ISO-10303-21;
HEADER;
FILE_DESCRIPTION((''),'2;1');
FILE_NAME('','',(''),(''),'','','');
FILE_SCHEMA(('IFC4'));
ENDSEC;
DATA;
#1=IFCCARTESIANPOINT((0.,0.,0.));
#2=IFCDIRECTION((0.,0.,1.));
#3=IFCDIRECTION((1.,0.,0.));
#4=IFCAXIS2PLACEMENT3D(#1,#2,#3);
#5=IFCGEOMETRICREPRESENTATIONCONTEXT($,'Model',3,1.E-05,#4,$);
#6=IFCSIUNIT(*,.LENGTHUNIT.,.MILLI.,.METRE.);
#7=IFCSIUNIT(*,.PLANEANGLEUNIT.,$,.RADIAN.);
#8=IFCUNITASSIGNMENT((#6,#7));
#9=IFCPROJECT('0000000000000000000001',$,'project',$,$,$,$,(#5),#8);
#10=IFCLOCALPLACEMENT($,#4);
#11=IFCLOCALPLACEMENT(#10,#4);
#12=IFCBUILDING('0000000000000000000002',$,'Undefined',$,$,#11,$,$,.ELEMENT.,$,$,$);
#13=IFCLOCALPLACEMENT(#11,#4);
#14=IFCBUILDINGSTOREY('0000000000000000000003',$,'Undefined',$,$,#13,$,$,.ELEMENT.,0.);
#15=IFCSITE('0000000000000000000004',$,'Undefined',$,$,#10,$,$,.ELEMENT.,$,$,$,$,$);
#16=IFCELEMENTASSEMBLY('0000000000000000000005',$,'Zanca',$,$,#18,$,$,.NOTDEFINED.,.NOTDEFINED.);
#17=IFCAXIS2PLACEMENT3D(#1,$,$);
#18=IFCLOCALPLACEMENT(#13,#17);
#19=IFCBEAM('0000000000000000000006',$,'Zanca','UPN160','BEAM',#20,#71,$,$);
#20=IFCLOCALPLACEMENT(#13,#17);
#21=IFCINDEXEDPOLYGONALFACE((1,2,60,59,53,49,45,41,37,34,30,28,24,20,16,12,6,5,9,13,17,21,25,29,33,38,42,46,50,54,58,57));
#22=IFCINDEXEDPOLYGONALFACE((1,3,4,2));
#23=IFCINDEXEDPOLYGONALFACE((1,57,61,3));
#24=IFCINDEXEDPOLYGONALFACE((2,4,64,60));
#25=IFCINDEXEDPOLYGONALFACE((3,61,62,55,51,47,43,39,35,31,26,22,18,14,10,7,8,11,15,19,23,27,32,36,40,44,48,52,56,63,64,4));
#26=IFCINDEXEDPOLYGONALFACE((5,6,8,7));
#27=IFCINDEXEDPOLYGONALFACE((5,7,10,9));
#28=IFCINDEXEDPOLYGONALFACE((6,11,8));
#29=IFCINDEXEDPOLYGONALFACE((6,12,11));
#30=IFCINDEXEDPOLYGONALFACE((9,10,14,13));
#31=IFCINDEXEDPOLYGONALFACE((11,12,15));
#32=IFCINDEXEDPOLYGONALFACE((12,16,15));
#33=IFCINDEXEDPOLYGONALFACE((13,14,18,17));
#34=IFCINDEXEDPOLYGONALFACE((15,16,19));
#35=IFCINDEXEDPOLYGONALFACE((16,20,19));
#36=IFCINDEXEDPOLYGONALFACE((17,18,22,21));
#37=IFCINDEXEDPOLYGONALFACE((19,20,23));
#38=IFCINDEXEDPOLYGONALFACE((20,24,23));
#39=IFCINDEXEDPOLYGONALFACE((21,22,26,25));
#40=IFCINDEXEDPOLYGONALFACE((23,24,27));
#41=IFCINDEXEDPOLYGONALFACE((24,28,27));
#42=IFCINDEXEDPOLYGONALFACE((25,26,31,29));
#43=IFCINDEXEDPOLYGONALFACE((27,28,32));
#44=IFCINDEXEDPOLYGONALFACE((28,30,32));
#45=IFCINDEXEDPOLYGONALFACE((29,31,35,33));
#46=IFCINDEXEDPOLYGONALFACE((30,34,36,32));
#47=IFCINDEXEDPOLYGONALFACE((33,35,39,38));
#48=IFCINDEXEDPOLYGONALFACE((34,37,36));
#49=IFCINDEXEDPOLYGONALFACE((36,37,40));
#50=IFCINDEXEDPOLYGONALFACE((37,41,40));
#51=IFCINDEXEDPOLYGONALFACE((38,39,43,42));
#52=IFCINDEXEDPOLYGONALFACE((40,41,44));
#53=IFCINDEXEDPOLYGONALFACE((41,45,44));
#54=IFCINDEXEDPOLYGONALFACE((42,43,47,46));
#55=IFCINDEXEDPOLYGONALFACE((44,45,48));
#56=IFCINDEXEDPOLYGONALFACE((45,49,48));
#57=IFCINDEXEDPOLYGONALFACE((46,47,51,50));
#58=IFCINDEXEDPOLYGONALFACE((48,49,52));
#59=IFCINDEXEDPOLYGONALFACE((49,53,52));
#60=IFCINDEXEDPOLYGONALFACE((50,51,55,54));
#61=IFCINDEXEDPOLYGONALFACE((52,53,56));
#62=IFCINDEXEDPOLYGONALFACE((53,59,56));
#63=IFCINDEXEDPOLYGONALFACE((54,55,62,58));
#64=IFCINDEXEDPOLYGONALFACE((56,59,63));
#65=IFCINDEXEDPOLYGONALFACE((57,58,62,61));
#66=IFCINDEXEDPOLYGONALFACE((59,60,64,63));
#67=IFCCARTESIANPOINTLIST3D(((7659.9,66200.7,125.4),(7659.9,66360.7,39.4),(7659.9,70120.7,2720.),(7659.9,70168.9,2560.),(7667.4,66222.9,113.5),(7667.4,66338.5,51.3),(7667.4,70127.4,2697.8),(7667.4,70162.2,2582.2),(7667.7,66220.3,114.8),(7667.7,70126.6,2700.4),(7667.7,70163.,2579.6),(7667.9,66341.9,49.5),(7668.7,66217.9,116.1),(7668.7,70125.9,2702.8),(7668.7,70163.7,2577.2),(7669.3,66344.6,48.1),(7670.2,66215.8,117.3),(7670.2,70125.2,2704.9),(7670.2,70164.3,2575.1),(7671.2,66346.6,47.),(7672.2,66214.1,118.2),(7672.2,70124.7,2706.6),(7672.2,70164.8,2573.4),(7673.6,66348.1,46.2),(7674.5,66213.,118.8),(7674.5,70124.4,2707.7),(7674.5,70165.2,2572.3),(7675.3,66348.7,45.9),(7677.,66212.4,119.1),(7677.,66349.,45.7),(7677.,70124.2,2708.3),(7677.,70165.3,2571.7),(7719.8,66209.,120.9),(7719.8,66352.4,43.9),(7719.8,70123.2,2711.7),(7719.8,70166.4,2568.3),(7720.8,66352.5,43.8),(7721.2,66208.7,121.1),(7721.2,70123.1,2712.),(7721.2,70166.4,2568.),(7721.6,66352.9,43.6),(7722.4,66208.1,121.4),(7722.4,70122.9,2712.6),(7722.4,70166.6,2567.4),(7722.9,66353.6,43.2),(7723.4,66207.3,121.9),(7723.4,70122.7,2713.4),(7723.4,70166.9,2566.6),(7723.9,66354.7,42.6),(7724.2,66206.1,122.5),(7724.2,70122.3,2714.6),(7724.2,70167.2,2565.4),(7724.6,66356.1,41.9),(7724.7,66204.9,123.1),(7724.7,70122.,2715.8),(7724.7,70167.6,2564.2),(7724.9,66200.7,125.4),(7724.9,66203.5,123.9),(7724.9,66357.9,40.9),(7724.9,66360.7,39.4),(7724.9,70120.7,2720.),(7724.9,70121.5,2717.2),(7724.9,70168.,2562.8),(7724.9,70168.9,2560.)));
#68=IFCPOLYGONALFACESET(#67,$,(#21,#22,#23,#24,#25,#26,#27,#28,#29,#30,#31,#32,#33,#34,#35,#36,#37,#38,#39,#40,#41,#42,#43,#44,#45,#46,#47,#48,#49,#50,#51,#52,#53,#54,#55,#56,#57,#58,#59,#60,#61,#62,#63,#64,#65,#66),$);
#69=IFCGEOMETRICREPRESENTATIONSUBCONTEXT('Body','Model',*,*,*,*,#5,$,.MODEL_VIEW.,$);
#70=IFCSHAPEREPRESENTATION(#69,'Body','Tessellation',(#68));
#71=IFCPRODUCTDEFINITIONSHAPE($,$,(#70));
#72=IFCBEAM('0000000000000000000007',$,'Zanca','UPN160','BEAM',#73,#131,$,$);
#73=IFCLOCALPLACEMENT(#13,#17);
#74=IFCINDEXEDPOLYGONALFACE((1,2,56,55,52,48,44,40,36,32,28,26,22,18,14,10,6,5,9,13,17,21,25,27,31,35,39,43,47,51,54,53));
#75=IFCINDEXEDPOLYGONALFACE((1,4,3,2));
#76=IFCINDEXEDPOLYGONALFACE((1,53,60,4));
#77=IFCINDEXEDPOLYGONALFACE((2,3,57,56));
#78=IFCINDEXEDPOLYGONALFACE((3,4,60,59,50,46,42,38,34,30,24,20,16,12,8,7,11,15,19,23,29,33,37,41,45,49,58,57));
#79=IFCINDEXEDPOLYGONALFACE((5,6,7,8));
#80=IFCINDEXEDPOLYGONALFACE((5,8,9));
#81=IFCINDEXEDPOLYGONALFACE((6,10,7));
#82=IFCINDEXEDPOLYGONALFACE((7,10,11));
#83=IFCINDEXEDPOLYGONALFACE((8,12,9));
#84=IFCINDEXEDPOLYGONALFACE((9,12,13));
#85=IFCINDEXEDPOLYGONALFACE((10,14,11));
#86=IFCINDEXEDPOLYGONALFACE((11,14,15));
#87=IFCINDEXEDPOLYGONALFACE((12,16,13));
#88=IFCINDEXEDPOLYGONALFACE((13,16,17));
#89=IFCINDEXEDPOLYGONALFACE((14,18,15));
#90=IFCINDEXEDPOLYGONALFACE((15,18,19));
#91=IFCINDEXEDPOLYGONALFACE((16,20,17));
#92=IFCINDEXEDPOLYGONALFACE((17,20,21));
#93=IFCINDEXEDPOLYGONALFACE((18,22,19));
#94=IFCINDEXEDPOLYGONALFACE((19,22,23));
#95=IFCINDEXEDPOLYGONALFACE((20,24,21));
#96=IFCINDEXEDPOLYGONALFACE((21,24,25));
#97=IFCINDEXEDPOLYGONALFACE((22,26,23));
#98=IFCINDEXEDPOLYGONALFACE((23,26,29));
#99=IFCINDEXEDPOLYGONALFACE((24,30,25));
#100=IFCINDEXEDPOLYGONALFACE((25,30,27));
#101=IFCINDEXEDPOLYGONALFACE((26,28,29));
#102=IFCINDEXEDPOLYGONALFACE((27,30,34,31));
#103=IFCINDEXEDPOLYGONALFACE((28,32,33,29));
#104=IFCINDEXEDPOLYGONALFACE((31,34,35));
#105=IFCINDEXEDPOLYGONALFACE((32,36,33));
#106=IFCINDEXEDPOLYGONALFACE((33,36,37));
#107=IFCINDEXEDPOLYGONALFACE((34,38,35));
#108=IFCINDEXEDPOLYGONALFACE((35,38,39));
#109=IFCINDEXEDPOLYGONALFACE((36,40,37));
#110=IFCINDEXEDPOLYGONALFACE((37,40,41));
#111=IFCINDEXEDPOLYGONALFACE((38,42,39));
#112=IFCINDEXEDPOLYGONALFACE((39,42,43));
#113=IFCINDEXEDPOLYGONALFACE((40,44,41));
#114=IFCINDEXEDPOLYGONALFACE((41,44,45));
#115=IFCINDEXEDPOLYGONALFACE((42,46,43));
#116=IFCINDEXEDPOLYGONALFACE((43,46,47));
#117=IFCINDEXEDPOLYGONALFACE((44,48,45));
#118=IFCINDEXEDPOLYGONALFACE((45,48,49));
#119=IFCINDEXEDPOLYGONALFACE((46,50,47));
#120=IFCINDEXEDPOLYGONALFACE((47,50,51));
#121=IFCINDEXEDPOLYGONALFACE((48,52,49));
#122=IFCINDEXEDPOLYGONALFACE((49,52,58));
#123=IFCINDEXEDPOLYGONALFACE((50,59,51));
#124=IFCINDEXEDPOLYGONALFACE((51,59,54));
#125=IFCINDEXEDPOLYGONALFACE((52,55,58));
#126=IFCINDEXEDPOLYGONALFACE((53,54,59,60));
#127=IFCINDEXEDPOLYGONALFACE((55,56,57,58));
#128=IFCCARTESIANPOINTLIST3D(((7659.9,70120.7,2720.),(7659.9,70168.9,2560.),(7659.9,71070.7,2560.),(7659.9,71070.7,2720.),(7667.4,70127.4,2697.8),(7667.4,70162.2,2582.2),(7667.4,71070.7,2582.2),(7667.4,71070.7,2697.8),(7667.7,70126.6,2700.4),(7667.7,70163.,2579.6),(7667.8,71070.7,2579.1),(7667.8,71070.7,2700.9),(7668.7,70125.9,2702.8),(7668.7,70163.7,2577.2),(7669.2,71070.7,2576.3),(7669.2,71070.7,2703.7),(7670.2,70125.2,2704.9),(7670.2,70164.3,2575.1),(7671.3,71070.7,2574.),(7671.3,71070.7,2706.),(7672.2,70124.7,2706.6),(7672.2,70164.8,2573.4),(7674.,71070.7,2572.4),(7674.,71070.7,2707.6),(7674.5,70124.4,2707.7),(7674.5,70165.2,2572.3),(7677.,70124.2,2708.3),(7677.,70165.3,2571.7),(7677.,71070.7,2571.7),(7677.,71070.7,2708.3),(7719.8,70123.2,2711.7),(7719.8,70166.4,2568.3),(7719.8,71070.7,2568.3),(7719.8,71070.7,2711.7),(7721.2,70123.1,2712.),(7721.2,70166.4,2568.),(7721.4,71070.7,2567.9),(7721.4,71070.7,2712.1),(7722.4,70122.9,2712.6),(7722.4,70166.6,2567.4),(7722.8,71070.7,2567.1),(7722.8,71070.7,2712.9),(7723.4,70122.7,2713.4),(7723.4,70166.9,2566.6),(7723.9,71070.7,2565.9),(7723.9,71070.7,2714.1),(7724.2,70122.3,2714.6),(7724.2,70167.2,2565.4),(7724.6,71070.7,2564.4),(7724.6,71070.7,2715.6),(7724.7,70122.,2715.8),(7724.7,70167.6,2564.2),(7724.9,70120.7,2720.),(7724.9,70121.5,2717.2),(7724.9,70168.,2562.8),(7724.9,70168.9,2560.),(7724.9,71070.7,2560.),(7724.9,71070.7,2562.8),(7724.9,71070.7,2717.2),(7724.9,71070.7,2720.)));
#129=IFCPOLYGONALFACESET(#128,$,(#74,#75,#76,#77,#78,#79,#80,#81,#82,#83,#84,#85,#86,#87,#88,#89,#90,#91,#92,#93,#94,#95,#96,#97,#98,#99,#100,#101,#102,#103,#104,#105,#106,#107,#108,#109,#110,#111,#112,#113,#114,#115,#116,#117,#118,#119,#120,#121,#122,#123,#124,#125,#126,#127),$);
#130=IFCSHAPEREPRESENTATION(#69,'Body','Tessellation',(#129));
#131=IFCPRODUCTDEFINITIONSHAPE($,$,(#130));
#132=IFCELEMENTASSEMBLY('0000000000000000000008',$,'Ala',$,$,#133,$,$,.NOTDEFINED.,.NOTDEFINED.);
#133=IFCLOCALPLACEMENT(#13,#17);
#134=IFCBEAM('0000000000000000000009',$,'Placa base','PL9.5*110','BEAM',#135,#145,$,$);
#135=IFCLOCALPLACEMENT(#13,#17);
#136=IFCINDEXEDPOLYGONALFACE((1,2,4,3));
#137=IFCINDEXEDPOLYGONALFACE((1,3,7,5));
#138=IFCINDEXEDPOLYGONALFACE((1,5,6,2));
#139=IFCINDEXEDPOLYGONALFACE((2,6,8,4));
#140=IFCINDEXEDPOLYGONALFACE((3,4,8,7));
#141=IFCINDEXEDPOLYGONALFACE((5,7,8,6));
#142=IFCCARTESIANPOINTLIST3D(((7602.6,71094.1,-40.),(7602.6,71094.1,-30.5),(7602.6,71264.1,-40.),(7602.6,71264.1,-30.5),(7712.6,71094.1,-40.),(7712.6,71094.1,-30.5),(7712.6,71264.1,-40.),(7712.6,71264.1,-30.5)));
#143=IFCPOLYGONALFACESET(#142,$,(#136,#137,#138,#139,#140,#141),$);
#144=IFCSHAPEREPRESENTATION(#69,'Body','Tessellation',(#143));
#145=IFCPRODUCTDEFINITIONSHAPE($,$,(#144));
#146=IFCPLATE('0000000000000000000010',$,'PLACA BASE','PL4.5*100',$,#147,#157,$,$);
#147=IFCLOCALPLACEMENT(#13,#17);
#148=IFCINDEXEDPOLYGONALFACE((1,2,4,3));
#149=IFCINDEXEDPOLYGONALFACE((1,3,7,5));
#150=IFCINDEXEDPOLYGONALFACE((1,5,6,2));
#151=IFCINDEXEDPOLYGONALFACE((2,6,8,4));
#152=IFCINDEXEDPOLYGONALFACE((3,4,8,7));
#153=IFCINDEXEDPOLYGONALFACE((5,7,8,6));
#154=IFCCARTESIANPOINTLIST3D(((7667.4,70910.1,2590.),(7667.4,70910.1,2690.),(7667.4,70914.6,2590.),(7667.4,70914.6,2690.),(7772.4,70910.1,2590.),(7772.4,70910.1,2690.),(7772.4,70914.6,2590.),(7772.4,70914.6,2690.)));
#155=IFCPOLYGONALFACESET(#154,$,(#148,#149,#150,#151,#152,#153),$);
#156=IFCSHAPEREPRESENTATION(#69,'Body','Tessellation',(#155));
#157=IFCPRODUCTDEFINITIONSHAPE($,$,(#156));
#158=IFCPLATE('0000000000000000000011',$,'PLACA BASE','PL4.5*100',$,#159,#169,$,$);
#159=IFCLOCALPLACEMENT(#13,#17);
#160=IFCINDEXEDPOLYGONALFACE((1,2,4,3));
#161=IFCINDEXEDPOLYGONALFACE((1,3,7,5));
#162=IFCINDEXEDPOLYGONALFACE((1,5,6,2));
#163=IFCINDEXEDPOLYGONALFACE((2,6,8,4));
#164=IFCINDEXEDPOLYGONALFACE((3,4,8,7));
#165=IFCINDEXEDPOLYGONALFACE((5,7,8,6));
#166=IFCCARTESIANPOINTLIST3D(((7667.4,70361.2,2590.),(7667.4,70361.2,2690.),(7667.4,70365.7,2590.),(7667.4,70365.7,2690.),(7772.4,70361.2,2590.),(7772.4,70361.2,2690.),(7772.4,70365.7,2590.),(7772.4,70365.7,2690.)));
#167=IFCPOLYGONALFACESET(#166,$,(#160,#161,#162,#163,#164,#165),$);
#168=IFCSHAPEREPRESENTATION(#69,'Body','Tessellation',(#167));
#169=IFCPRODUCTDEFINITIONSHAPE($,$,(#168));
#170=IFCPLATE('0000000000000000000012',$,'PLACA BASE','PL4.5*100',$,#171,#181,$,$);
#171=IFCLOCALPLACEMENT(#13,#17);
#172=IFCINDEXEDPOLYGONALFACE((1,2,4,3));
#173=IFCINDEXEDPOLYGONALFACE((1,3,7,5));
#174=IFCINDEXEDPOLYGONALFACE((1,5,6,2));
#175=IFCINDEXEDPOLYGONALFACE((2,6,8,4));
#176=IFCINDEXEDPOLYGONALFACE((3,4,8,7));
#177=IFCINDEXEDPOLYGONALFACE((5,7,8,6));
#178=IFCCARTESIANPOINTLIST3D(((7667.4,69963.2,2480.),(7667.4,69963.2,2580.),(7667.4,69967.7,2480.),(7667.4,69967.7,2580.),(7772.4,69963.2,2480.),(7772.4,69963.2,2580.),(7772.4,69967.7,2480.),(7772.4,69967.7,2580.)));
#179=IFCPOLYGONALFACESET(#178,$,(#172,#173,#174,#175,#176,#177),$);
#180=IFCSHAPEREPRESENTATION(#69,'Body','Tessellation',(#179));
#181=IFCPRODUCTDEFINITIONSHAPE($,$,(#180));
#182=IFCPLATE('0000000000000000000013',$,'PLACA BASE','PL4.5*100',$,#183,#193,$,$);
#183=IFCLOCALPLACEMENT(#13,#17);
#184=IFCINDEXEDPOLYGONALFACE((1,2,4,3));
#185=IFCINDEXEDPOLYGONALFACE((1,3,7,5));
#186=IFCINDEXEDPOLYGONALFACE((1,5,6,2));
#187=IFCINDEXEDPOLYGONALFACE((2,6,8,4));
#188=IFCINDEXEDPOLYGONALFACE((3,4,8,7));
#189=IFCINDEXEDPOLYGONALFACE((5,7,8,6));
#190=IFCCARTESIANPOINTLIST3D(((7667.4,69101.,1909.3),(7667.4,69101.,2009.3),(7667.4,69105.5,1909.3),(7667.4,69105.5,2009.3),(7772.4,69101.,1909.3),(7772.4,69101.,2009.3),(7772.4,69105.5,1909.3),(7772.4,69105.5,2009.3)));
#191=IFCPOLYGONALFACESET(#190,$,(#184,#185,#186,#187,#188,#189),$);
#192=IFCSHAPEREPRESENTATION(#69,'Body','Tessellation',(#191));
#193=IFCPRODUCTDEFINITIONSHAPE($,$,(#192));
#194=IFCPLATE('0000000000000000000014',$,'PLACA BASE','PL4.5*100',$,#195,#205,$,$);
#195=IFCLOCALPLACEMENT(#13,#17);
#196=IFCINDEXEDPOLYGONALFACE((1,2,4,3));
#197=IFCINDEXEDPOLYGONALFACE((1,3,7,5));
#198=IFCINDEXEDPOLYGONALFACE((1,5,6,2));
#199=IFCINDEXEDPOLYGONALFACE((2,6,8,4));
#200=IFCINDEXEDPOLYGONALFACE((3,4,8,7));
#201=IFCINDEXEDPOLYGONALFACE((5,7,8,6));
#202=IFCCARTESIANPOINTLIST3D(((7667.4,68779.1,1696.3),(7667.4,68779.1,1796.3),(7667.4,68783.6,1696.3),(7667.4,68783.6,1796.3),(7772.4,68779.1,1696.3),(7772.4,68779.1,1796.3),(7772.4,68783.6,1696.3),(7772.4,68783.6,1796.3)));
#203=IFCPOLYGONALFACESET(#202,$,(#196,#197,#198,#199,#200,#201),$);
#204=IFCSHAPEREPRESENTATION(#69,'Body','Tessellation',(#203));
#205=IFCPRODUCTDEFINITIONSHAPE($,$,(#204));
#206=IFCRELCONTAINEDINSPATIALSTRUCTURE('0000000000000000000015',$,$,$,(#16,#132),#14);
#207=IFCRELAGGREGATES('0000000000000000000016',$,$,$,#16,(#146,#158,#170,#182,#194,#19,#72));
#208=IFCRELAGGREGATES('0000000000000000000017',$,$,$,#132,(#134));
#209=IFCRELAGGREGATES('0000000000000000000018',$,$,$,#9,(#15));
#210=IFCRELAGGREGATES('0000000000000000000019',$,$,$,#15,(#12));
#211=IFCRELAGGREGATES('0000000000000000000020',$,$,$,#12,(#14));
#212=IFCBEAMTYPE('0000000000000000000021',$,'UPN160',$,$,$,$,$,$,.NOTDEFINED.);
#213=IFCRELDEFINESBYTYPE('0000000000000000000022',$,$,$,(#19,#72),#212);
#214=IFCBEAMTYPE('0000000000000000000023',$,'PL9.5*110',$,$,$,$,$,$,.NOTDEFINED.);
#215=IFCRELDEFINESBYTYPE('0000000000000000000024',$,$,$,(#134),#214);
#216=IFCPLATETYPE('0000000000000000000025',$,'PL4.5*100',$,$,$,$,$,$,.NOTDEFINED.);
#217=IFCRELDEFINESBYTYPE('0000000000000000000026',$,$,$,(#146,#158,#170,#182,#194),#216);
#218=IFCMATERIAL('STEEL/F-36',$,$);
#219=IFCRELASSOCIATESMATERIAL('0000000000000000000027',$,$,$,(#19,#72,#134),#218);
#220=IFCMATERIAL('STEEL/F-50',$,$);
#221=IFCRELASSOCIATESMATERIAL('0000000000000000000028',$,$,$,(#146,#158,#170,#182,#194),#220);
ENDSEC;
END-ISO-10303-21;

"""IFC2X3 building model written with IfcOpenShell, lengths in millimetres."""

from ifc_helpers import new_model, si_unit, frame, origin_with_axes, origin_2d_with_axis, place, context, subcontext, project, spatial, polyline, rectangle, u_section, outline, extrude, clip, halfspace, material, type_object, element, aggregate, save


model = new_model("IFC2X3")

# Units and contexts
model_context = context("Model", 3, precision=1e-05, world=origin_with_axes())
body_context = subcontext(model_context, "Body", "Model", "MODEL_VIEW")
ifc_project = project(units=[si_unit("LENGTHUNIT", "METRE", prefix="MILLI"), si_unit("PLANEANGLEUNIT", "RADIAN")], contexts=[model_context])

# Site, building, storey
site_placement = place(None, origin_with_axes())
site = spatial("IfcSite", under=ifc_project, at=site_placement, Name="Undefined", CompositionType="ELEMENT")
building_placement = place(site_placement, origin_with_axes())
building = spatial("IfcBuilding", under=site, at=building_placement, Name="Undefined", CompositionType="ELEMENT")
storey_placement = place(building_placement, origin_with_axes())
storey = spatial("IfcBuildingStorey", under=building, at=storey_placement, Name="Undefined", CompositionType="ELEMENT", Elevation=0.0)

# Element assembly
assembly_1_placement = place(storey_placement, origin_with_axes())
assembly_1 = element("IfcElementAssembly", 1, at=assembly_1_placement, inside=storey, Name="Zanca", AssemblyPlace="NOTDEFINED", PredefinedType="NOTDEFINED")
ifc_material_1 = material(Name="STEEL/F-36")

# Shared definitions
beam_type_1 = type_object("IfcBeamType", Name="UPN160", PredefinedType="NOTDEFINED")

# Beams
beam_1_placement = place(assembly_1_placement, frame((7692.4, 70164.9, 2653.3), z_axis=(0.0, 0.551942, -0.833883), x_axis=(0.0, -0.833883, -0.551942)))
beam_1 = element("IfcBeam", 2, at=beam_1_placement, type_object=beam_type_1, material=ifc_material_1, Name="Zanca", Description="UPN160", ObjectType="BEAM", context=body_context, shape_type="Clipping", body=[
    clip(clip(extrude(u_section(Depth=160.0, FlangeWidth=65.0, WebThickness=7.5, FlangeThickness=10.5, FilletRadius=10.5, EdgeRadius=5.5, FlangeSlope=0.07983, at=origin_2d_with_axis()), frame((4814.1, 0.0, 0.0), z_axis=(-1.0, 0.0, 0.0), x_axis=(0.0, -1.0, 0.0)), (0.0, 0.0, 1.0), 4946.3), halfspace(frame((4700.9, 0.0, -80.0), z_axis=(0.880892, 0.0, 0.473317), x_axis=(0.0, -1.0, 0.0)), False)), halfspace(frame((0.0, 0.0, -80.0), z_axis=(0.957571, 0.0, -0.288199), x_axis=(0.0, -1.0, 0.0)), True)),
])
beam_2_placement = place(assembly_1_placement, frame((7692.4, 71070.7, 2640.0), z_axis=(0.0, 0.0, -1.0), x_axis=(0.0, -1.0, 0.0)))
beam_2 = element("IfcBeam", 3, at=beam_2_placement, type_object=beam_type_1, material=ifc_material_1, Name="Zanca", Description="UPN160", ObjectType="BEAM", context=body_context, shape_type="Clipping", body=[
    clip(extrude(u_section(Depth=160.0, FlangeWidth=65.0, WebThickness=7.5, FlangeThickness=10.5, FilletRadius=10.5, EdgeRadius=5.5, FlangeSlope=0.07983, at=origin_2d_with_axis()), frame((950.2, 0.0, 0.0), z_axis=(-1.0, 0.0, 0.0), x_axis=(0.0, -1.0, 0.0)), (0.0, 0.0, 1.0), 950.2), halfspace(frame((950.0, 0.0, -80.0), z_axis=(0.957571, 0.0, 0.288199), x_axis=(0.0, -1.0, 0.0)), False)),
])

# Element assembly, beam
assembly_2_placement = place(storey_placement, origin_with_axes())
assembly_2 = element("IfcElementAssembly", 4, at=assembly_2_placement, inside=storey, Name="Ala", AssemblyPlace="NOTDEFINED", PredefinedType="NOTDEFINED")
beam_type_2 = type_object("IfcBeamType", Name="PL9.5*110", PredefinedType="NOTDEFINED")
beam_3_placement = place(assembly_2_placement, frame((7657.6, 71094.1, -35.3), z_axis=(-1.0, 0.0, 0.0), x_axis=(0.0, 1.0, 0.0)))
beam_3 = element("IfcBeam", 5, at=beam_3_placement, type_object=beam_type_2, material=ifc_material_1, Name="Placa base", Description="PL9.5*110", ObjectType="BEAM", context=body_context, shape_type="SweptSolid", body=[
    extrude(rectangle(XDim=9.5, YDim=110.0, at=origin_2d_with_axis()), frame((170.0, 0.0, 0.0), z_axis=(-1.0, 0.0, 0.0), x_axis=(0.0, -1.0, 0.0)), (0.0, 0.0, 1.0), 170.0),
])

# Plates
ifc_material_2 = material(Name="STEEL/F-50")
plate_type_1 = type_object("IfcPlateType", Name="PL4.5*100", PredefinedType="NOTDEFINED")
plate_1_placement = place(assembly_1_placement, frame((7772.4, 70912.3, 2590.0), z_axis=(0.0, 1.0, 0.0), x_axis=(-1.0, 0.0, 0.0)))
plate_1 = element("IfcPlate", 6, at=plate_1_placement, type_object=plate_type_1, material=ifc_material_2, Name="PLACA BASE", Description="PL4.5*100", context=body_context, shape_type="SweptSolid", body=[
    extrude(outline(polyline([(0.0, 0.0), (105.0, 0.0), (105.0, 100.0), (0.0, 100.0), (0.0, 0.0)])), frame((0.0, 0.0, -2.2), z_axis=(0.0, 0.0, 1.0), x_axis=(1.0, 0.0, 0.0)), (0.0, 0.0, 1.0), 4.5),
])
plate_2_placement = place(assembly_1_placement, frame((7772.4, 70363.5, 2590.0), z_axis=(0.0, 1.0, 0.0), x_axis=(-1.0, 0.0, 0.0)))
plate_2 = element("IfcPlate", 7, at=plate_2_placement, type_object=plate_type_1, material=ifc_material_2, Name="PLACA BASE", Description="PL4.5*100", context=body_context, shape_type="SweptSolid", body=[
    extrude(outline(polyline([(0.0, 0.0), (105.0, 0.0), (105.0, 100.0), (0.0, 100.0), (0.0, 0.0)])), frame((0.0, 0.0, -2.2), z_axis=(0.0, 0.0, 1.0), x_axis=(1.0, 0.0, 0.0)), (0.0, 0.0, 1.0), 4.5),
])
plate_3_placement = place(assembly_1_placement, frame((7772.4, 69965.4, 2480.0), z_axis=(0.0, 1.0, 0.0), x_axis=(-1.0, 0.0, 0.0)))
plate_3 = element("IfcPlate", 8, at=plate_3_placement, type_object=plate_type_1, material=ifc_material_2, Name="PLACA BASE", Description="PL4.5*100", context=body_context, shape_type="SweptSolid", body=[
    extrude(outline(polyline([(0.0, 0.0), (105.0, 0.0), (105.0, 100.0), (0.0, 100.0), (0.0, 0.0)])), frame((0.0, 0.0, -2.2), z_axis=(0.0, 0.0, 1.0), x_axis=(1.0, 0.0, 0.0)), (0.0, 0.0, 1.0), 4.5),
])
plate_4_placement = place(assembly_1_placement, frame((7772.4, 69103.2, 1909.3), z_axis=(0.0, 1.0, 0.0), x_axis=(-1.0, 0.0, 0.0)))
plate_4 = element("IfcPlate", 9, at=plate_4_placement, type_object=plate_type_1, material=ifc_material_2, Name="PLACA BASE", Description="PL4.5*100", context=body_context, shape_type="SweptSolid", body=[
    extrude(outline(polyline([(0.0, 0.0), (105.0, 0.0), (105.0, 100.0), (0.0, 100.0), (0.0, 0.0)])), frame((0.0, 0.0, -2.2), z_axis=(0.0, 0.0, 1.0), x_axis=(1.0, 0.0, 0.0)), (0.0, 0.0, 1.0), 4.5),
])
plate_5_placement = place(assembly_1_placement, frame((7772.4, 68781.3, 1696.3), z_axis=(0.0, 1.0, 0.0), x_axis=(-1.0, 0.0, 0.0)))
plate_5 = element("IfcPlate", 10, at=plate_5_placement, type_object=plate_type_1, material=ifc_material_2, Name="PLACA BASE", Description="PL4.5*100", context=body_context, shape_type="SweptSolid", body=[
    extrude(outline(polyline([(0.0, 0.0), (105.0, 0.0), (105.0, 100.0), (0.0, 100.0), (0.0, 0.0)])), frame((0.0, 0.0, -2.2), z_axis=(0.0, 0.0, 1.0), x_axis=(1.0, 0.0, 0.0)), (0.0, 0.0, 1.0), 4.5),
])
aggregate(assembly_1, [plate_1, plate_2, plate_3, plate_4, plate_5, beam_1, beam_2])

aggregate(assembly_2, [beam_3])

save(model, "model.ifc")
